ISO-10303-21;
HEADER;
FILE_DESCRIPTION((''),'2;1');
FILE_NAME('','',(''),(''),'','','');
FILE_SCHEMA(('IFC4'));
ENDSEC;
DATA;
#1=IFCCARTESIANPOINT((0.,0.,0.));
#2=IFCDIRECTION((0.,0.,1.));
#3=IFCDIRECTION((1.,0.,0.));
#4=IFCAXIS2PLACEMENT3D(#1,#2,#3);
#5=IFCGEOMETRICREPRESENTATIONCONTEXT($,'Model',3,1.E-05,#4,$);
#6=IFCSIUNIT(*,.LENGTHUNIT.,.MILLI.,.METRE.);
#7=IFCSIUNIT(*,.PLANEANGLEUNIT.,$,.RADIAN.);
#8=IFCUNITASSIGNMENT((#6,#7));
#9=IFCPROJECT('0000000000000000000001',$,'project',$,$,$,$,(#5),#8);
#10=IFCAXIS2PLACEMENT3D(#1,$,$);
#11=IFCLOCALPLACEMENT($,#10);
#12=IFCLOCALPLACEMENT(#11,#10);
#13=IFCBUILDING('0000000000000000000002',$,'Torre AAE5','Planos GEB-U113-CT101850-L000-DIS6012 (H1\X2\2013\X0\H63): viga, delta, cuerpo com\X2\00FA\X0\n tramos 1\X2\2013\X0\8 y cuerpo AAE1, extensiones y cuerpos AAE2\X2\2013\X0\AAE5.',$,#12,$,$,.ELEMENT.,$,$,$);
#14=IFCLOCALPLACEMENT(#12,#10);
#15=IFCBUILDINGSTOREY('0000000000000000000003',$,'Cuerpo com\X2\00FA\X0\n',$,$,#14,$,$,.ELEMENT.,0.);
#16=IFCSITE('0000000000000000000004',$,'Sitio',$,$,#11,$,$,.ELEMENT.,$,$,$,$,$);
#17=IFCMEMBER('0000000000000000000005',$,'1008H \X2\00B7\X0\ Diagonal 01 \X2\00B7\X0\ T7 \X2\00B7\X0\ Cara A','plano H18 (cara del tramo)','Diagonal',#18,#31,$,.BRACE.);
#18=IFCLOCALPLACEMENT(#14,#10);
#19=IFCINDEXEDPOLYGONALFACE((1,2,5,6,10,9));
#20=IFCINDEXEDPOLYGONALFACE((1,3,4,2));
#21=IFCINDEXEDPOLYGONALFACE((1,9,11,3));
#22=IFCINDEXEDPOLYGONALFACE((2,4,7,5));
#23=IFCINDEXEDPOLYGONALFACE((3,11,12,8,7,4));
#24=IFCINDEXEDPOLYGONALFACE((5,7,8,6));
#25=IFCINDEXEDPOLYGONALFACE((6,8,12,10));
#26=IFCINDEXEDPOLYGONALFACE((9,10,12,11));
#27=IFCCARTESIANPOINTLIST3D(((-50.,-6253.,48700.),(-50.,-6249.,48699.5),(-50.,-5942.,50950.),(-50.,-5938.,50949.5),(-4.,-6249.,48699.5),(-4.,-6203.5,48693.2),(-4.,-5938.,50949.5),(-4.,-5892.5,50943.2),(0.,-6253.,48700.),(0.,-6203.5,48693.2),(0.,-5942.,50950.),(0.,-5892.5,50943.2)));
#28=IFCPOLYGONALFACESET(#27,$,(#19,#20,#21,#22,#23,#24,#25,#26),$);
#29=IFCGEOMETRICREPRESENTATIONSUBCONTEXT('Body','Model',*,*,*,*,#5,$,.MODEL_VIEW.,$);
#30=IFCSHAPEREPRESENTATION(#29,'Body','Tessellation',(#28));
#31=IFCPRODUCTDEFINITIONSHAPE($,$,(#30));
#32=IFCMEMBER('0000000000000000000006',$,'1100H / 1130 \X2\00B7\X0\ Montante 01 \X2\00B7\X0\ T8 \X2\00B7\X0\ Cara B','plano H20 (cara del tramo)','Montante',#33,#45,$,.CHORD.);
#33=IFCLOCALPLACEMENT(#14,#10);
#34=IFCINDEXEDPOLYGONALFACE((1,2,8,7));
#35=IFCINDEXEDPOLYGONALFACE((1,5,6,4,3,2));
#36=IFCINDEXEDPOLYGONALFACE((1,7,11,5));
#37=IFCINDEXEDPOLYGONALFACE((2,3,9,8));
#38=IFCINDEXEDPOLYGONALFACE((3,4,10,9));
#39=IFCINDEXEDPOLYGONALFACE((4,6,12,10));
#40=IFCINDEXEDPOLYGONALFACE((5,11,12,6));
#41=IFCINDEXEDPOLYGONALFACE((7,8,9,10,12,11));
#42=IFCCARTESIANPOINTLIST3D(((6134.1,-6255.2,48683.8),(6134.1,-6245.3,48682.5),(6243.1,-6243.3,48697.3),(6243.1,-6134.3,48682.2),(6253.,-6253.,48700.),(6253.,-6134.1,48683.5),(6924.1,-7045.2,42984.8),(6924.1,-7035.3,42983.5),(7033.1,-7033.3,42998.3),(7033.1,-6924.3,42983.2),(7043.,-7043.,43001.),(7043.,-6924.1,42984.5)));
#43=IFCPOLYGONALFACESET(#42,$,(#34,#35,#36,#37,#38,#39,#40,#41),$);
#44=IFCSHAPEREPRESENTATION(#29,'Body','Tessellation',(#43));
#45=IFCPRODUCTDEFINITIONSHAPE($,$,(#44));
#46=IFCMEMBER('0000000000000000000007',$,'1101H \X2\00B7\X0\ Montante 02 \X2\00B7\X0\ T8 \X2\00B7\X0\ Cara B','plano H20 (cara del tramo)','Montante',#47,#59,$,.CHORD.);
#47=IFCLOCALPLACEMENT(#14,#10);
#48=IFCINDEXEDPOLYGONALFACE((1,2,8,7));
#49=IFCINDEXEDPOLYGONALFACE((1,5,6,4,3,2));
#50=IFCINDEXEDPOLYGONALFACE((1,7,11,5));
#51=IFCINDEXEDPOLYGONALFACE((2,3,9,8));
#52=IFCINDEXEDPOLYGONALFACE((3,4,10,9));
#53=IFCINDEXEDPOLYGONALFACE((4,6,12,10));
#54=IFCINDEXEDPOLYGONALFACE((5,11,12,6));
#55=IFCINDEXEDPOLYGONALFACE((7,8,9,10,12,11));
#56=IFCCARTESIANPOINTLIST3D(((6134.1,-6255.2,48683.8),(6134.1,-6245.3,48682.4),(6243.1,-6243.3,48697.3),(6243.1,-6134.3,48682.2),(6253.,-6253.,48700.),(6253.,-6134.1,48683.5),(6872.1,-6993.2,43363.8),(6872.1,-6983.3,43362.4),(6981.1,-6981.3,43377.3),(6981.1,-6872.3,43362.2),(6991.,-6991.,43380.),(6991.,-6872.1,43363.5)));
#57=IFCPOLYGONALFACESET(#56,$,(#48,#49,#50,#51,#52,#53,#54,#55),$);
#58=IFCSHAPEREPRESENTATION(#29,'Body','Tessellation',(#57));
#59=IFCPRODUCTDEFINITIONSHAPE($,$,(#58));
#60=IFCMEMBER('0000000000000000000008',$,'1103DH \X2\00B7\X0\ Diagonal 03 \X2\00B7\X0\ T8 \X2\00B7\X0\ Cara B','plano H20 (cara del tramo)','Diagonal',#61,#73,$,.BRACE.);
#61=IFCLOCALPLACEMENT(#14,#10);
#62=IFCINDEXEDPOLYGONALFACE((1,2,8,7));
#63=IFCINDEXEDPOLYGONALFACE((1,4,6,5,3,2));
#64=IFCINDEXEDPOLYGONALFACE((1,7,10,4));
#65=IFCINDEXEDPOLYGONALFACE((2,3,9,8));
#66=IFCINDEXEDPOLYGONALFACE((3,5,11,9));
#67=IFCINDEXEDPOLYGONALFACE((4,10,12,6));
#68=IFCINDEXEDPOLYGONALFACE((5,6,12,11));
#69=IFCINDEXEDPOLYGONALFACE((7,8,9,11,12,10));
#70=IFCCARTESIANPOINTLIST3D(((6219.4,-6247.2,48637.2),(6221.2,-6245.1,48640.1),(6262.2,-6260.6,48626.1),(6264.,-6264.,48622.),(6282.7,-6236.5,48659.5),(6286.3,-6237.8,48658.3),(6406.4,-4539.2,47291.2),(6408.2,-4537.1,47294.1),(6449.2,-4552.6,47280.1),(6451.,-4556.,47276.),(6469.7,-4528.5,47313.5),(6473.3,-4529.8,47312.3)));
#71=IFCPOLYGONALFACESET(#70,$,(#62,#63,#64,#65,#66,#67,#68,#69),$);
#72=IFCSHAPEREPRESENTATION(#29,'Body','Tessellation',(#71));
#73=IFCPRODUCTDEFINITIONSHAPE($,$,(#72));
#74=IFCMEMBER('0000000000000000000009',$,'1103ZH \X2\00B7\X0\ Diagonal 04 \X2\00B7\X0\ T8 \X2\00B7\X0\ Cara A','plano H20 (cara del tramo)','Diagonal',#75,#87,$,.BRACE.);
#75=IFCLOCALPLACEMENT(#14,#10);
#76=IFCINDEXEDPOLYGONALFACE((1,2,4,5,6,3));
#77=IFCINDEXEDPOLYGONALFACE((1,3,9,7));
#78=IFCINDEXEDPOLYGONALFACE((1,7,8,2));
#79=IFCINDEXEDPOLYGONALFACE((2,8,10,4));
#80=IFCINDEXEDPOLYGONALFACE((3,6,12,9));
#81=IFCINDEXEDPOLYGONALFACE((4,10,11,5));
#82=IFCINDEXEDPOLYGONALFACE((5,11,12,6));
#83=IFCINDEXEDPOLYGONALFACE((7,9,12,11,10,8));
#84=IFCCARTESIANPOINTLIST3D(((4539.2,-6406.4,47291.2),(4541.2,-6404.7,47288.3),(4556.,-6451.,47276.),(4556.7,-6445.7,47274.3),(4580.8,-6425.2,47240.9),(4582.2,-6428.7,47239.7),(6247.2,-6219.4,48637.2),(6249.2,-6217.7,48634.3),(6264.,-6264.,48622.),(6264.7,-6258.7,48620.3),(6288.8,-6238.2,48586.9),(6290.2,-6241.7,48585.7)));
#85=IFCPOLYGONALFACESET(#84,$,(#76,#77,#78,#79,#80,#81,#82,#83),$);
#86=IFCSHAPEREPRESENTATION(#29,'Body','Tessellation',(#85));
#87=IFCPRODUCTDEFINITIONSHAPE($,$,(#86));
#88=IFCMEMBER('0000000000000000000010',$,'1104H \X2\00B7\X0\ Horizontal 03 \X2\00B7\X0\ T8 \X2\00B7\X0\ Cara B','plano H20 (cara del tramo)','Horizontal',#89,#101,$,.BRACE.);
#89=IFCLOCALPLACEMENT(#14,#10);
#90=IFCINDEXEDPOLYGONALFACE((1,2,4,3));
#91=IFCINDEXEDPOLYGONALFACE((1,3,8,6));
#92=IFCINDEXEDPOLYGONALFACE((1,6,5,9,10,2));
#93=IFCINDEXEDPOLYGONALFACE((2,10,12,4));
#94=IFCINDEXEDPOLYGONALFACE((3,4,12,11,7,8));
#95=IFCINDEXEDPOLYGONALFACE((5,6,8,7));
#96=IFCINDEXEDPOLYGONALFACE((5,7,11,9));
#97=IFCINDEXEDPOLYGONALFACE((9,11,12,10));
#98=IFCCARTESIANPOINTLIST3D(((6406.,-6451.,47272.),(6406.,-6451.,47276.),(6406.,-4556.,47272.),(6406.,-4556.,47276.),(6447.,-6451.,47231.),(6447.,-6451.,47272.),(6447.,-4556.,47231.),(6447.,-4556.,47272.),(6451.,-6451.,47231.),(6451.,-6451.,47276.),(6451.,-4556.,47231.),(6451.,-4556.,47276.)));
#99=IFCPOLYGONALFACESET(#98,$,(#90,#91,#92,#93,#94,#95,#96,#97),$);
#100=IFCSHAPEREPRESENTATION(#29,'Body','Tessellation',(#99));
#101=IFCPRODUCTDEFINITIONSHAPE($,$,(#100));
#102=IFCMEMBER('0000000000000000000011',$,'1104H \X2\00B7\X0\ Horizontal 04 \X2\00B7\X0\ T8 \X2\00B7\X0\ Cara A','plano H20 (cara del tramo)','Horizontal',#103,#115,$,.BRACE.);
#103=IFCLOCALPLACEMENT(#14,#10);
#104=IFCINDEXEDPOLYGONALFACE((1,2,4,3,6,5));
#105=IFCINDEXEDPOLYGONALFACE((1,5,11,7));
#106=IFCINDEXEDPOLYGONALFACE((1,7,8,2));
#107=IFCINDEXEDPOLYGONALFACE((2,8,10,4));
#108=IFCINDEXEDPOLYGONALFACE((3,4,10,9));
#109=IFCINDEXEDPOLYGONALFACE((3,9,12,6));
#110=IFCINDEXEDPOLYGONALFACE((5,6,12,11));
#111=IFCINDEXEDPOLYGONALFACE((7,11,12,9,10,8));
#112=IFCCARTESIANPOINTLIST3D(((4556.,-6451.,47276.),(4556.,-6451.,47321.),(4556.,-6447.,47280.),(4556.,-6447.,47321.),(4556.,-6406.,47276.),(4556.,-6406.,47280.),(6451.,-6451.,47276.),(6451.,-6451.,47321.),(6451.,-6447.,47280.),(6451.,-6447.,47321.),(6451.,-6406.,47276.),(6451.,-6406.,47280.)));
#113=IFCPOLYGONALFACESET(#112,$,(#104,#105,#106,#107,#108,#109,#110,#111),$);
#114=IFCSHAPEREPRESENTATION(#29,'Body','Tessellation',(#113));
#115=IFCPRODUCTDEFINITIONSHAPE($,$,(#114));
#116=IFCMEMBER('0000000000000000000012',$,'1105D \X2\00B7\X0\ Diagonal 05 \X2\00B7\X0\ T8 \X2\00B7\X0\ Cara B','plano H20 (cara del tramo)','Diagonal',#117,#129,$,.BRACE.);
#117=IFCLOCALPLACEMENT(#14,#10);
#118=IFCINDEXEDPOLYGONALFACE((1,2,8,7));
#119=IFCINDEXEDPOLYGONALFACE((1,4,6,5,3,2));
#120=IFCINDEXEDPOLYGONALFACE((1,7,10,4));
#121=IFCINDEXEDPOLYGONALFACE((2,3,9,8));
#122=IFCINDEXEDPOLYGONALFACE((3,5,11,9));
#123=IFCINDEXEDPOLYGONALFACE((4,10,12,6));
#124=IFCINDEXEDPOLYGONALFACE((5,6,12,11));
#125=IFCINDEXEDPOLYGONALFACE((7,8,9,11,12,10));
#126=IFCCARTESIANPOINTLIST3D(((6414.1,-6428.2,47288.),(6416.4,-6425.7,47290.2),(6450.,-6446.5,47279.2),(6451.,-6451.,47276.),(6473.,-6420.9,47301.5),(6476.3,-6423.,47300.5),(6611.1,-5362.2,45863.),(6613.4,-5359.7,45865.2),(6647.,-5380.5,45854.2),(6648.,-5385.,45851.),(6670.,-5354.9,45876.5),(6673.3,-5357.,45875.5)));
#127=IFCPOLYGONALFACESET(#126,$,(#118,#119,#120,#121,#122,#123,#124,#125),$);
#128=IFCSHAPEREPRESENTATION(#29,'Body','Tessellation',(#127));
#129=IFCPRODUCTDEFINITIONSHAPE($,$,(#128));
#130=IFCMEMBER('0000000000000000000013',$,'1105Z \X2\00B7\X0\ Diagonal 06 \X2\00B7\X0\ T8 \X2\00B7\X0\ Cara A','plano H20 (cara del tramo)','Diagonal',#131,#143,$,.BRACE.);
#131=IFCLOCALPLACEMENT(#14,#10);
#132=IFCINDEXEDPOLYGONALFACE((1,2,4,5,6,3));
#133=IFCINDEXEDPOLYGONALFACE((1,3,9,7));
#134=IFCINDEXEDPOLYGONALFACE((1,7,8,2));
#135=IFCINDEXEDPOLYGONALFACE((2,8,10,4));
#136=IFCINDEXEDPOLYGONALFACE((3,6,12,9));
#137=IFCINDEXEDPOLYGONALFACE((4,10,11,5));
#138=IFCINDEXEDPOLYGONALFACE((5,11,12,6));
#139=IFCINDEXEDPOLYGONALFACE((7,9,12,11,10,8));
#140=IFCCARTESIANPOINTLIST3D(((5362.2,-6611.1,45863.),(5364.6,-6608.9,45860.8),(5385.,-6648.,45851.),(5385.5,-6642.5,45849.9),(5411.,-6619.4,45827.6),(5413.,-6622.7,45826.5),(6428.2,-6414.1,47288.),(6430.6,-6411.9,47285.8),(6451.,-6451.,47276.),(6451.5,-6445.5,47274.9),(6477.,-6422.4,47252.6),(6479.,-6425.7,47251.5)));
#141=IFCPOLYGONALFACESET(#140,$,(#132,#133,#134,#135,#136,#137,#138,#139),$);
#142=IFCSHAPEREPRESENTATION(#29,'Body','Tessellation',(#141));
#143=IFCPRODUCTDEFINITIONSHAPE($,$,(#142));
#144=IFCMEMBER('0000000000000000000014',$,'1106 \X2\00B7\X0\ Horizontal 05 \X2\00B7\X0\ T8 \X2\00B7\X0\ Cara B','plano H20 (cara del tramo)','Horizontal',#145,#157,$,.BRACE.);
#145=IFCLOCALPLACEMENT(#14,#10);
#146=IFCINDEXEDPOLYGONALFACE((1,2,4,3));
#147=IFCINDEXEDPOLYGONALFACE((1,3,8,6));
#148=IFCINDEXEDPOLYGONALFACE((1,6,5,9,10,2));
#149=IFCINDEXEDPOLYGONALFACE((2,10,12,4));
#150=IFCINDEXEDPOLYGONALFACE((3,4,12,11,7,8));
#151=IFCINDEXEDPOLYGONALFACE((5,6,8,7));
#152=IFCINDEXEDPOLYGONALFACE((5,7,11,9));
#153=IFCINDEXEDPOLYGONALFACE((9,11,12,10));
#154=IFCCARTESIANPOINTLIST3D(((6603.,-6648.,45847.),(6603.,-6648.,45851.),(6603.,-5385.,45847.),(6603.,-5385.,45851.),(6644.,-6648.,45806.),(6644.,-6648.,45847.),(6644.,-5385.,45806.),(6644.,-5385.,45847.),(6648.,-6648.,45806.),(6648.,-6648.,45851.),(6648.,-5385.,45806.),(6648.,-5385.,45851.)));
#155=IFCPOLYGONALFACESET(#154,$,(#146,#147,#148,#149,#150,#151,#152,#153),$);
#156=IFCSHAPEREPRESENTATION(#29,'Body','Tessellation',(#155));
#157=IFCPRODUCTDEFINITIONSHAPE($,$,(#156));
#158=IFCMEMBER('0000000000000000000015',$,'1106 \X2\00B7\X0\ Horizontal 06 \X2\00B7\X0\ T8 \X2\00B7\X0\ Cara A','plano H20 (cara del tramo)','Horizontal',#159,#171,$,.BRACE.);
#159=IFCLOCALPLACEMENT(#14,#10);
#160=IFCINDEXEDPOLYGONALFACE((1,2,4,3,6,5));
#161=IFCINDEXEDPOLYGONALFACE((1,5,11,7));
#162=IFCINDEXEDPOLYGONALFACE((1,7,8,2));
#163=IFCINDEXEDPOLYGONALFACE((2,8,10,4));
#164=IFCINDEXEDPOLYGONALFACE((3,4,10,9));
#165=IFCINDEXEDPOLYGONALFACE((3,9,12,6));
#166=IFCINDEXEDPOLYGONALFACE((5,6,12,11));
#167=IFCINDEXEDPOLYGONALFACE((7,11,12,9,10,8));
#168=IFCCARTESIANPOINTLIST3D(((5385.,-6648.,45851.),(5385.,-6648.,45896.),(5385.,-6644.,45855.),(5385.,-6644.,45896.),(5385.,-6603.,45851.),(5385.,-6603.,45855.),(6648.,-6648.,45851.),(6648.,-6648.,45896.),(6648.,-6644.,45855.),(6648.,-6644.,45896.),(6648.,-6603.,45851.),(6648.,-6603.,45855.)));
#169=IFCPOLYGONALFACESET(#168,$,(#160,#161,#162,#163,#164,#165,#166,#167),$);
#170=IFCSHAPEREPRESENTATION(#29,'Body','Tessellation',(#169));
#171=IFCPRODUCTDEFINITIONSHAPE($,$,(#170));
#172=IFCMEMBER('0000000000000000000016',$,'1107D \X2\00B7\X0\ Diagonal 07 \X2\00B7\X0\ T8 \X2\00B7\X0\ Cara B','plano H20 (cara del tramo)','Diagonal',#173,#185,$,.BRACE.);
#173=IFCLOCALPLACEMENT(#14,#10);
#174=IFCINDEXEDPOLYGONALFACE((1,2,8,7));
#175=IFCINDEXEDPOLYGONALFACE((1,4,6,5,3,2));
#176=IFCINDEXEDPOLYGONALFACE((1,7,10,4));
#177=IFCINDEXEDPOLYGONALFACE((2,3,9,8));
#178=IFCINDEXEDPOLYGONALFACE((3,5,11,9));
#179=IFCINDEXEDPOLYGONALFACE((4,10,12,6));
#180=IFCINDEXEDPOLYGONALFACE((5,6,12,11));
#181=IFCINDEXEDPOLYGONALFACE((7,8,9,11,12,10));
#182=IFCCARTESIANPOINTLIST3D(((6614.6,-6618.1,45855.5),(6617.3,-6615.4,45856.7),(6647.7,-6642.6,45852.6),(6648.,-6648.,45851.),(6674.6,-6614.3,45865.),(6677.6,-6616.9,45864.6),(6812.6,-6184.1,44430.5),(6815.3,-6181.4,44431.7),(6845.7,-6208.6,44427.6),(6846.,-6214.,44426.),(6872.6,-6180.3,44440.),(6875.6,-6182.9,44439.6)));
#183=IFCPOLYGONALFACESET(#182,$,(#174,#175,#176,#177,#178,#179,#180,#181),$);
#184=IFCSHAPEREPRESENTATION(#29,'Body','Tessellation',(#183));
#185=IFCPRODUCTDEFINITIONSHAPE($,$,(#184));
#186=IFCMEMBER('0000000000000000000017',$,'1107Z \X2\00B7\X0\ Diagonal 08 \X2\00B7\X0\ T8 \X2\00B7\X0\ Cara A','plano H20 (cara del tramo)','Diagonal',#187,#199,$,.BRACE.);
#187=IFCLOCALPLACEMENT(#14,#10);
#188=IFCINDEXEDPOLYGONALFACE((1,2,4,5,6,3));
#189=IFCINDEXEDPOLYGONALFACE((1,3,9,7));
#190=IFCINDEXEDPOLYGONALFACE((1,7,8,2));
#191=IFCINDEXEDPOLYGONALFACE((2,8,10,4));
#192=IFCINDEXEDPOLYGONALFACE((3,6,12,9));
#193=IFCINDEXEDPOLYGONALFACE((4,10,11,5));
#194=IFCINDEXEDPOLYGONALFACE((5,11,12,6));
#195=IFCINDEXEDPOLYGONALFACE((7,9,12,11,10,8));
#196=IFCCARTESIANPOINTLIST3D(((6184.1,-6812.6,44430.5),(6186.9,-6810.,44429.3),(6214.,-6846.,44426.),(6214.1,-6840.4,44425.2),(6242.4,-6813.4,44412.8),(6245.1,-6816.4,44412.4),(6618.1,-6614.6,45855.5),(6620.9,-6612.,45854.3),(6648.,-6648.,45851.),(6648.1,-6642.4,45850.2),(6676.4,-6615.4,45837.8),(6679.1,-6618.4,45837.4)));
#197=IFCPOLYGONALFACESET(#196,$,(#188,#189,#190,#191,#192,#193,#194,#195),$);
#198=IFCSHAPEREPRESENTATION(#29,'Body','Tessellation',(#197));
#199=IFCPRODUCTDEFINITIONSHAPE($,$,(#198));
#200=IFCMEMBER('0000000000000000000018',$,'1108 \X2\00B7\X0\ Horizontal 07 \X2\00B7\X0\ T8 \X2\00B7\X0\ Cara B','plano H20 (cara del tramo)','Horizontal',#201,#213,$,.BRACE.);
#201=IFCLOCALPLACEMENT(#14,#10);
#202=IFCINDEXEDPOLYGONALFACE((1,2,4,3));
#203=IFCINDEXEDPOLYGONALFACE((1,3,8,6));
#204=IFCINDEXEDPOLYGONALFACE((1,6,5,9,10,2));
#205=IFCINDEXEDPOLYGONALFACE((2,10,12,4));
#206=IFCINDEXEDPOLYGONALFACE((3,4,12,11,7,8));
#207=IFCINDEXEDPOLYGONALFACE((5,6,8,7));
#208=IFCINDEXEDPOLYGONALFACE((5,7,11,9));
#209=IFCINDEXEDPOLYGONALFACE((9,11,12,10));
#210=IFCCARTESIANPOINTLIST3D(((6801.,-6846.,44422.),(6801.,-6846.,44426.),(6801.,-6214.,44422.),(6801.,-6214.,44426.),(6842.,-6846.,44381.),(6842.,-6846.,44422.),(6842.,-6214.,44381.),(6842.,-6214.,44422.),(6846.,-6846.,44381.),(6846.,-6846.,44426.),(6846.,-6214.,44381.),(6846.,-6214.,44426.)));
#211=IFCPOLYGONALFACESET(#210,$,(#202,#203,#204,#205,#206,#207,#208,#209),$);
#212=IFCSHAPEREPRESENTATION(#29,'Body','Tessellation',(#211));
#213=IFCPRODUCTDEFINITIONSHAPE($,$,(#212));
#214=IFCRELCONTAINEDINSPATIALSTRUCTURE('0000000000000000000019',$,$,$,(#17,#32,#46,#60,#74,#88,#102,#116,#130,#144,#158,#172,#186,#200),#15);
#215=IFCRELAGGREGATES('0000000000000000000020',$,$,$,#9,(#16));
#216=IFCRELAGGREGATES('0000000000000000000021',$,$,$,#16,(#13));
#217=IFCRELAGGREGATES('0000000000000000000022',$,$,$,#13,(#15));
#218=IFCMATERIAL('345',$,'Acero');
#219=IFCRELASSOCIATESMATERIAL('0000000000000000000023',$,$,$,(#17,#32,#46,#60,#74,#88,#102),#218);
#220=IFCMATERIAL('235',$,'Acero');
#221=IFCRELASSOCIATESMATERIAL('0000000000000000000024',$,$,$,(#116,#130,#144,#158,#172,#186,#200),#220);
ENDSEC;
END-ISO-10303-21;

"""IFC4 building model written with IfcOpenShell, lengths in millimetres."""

from ifc_helpers import new_model, si_unit, frame, frame_2d, origin, origin_with_axes, place, context, subcontext, project, spatial, l_section, extrude, material, element, save


model = new_model("IFC4")

# Units and contexts
model_context = context("Model", 3, precision=1e-05, world=origin_with_axes())
body_context = subcontext(model_context, "Body", "Model", "MODEL_VIEW")
ifc_project = project(units=[si_unit("LENGTHUNIT", "METRE", prefix="MILLI"), si_unit("PLANEANGLEUNIT", "RADIAN")], contexts=[model_context])

# Site, building, storey
site_placement = place(None, origin())
site = spatial("IfcSite", under=ifc_project, at=site_placement, Name="Sitio", CompositionType="ELEMENT")
building_placement = place(site_placement, origin())
building = spatial("IfcBuilding", under=site, at=building_placement, Name="Torre AAE5", Description="Planos GEB-U113-CT101850-L000-DIS6012 (H1–H63): viga, delta, cuerpo común tramos 1–8 y cuerpo AAE1, extensiones y cuerpos AAE2–AAE5.", CompositionType="ELEMENT")
storey_placement = place(building_placement, origin())
storey = spatial("IfcBuildingStorey", under=building, at=storey_placement, Name="Cuerpo común", CompositionType="ELEMENT", Elevation=0.0)

# Members
ifc_material_1 = material(Name="345", Category="Acero")
member_1_placement = place(storey_placement, frame((0.0, -6253.0, 48700.0), z_axis=(0.0, 0.13692, 0.990582), x_axis=(0.0, 0.990582, -0.13692)))
element("IfcMember", 1, at=member_1_placement, inside=storey, material=ifc_material_1, Name="1008H · Diagonal 01 · T7 · Cara A", Description="plano H18 (cara del tramo)", ObjectType="Diagonal", PredefinedType="BRACE", context=body_context, shape_type="SweptSolid", body=[
    extrude(l_section(Depth=50.0, Width=50.0, Thickness=4.0, at=frame_2d((25.0, 25.0))), None, (0.0, 0.0, 1.0), 2271.4),
])
member_2_placement = place(storey_placement, frame((6253.0, -6253.0, 48700.0), z_axis=(0.136032, -0.136032, -0.981321), x_axis=(-0.990705, -0.018678, -0.134743)))
element("IfcMember", 2, at=member_2_placement, inside=storey, material=ifc_material_1, Name="1100H / 1130 · Montante 01 · T8 · Cara B", Description="plano H20 (cara del tramo)", ObjectType="Montante", PredefinedType="CHORD", context=body_context, shape_type="SweptSolid", body=[
    extrude(l_section(Depth=120.0, Width=120.0, Thickness=10.0, at=frame_2d((60.0, 60.0))), None, (0.0, 0.0, 1.0), 5807.5),
])
member_3_placement = place(storey_placement, frame((6253.0, -6253.0, 48700.0), z_axis=(0.136127, -0.136127, -0.981295), x_axis=(-0.990691, -0.018705, -0.134836)))
element("IfcMember", 3, at=member_3_placement, inside=storey, material=ifc_material_1, Name="1101H · Montante 02 · T8 · Cara B", Description="plano H20 (cara del tramo)", ObjectType="Montante", PredefinedType="CHORD", context=body_context, shape_type="SweptSolid", body=[
    extrude(l_section(Depth=120.0, Width=120.0, Thickness=10.0, at=frame_2d((60.0, 60.0))), None, (0.0, 0.0, 1.0), 5421.4),
])
for number, where, z_axis, x_axis, name in (
    (4, (6264.0, -6264.0, 48622.0), (0.085676, 0.782536, -0.616682), (-0.891166, 0.336961, 0.303776), "1103DH · Diagonal 03 · T8 · Cara B"),
    (5, (6264.0, -6264.0, 48622.0), (-0.782536, -0.085676, -0.616682), (-0.336961, 0.891166, 0.303776), "1103ZH · Diagonal 04 · T8 · Cara A"),
):
    element("IfcMember", number, at=place(storey_placement, frame(where, z_axis=z_axis, x_axis=x_axis)), inside=storey, material=ifc_material_1, Name=name, Description="plano H20 (cara del tramo)", ObjectType="Diagonal", PredefinedType="BRACE", context=body_context, shape_type="SweptSolid", body=[
        extrude(l_section(Depth=50.0, Width=50.0, Thickness=4.0, at=frame_2d((25.0, 25.0))), None, (0.0, 0.0, 1.0), 2182.6),
    ])
for number, where, z_axis, x_axis, name in (
    (6, (6451.0, -4556.0, 47276.0), (0.0, -1.0, 0.0), (-1.0, 0.0, 0.0), "1104H · Horizontal 03 · T8 · Cara B"),
    (7, (4556.0, -6451.0, 47276.0), (1.0, 0.0, 0.0), (0.0, 1.0, 0.0), "1104H · Horizontal 04 · T8 · Cara A"),
):
    element("IfcMember", number, at=place(storey_placement, frame(where, z_axis=z_axis, x_axis=x_axis)), inside=storey, material=ifc_material_1, Name=name, Description="plano H20 (cara del tramo)", ObjectType="Horizontal", PredefinedType="BRACE", context=body_context, shape_type="SweptSolid", body=[
        extrude(l_section(Depth=45.0, Width=45.0, Thickness=4.0, at=frame_2d((22.5, 22.5))), None, (0.0, 0.0, 1.0), 1895.0),
    ])
ifc_material_2 = material(Name="235", Category="Acero")
for number, where, z_axis, x_axis, name in (
    (8, (6451.0, -6451.0, 47276.0), (0.110027, 0.595374, -0.79588), (-0.819305, 0.507658, 0.266499), "1105D · Diagonal 05 · T8 · Cara B"),
    (9, (6451.0, -6451.0, 47276.0), (-0.595374, -0.110027, -0.79588), (-0.507658, 0.819305, 0.266499), "1105Z · Diagonal 06 · T8 · Cara A"),
):
    element("IfcMember", number, at=place(storey_placement, frame(where, z_axis=z_axis, x_axis=x_axis)), inside=storey, material=ifc_material_2, Name=name, Description="plano H20 (cara del tramo)", ObjectType="Diagonal", PredefinedType="BRACE", context=body_context, shape_type="SweptSolid", body=[
        extrude(l_section(Depth=45.0, Width=45.0, Thickness=4.0, at=frame_2d((22.5, 22.5))), None, (0.0, 0.0, 1.0), 1790.5),
    ])
for number, where, z_axis, x_axis, name in (
    (10, (6648.0, -5385.0, 45851.0), (0.0, -1.0, 0.0), (-1.0, 0.0, 0.0), "1106 · Horizontal 05 · T8 · Cara B"),
    (11, (5385.0, -6648.0, 45851.0), (1.0, 0.0, 0.0), (0.0, 1.0, 0.0), "1106 · Horizontal 06 · T8 · Cara A"),
):
    element("IfcMember", number, at=place(storey_placement, frame(where, z_axis=z_axis, x_axis=x_axis)), inside=storey, material=ifc_material_2, Name=name, Description="plano H20 (cara del tramo)", ObjectType="Horizontal", PredefinedType="BRACE", context=body_context, shape_type="SweptSolid", body=[
        extrude(l_section(Depth=45.0, Width=45.0, Thickness=4.0, at=frame_2d((22.5, 22.5))), None, (0.0, 0.0, 1.0), 1263.0),
    ])
for number, where, z_axis, x_axis, name in (
    (12, (6648.0, -6648.0, 45851.0), (0.131761, 0.288808, -0.948277), (-0.741556, 0.663539, 0.099051), "1107D · Diagonal 07 · T8 · Cara B"),
    (13, (6648.0, -6648.0, 45851.0), (-0.288808, -0.131761, -0.948277), (-0.663539, 0.741556, 0.099051), "1107Z · Diagonal 08 · T8 · Cara A"),
):
    element("IfcMember", number, at=place(storey_placement, frame(where, z_axis=z_axis, x_axis=x_axis)), inside=storey, material=ifc_material_2, Name=name, Description="plano H20 (cara del tramo)", ObjectType="Diagonal", PredefinedType="BRACE", context=body_context, shape_type="SweptSolid", body=[
        extrude(l_section(Depth=45.0, Width=45.0, Thickness=4.0, at=frame_2d((22.5, 22.5))), None, (0.0, 0.0, 1.0), 1502.7),
    ])
for number, where, z_axis, x_axis, name in (
    (14, (6846.0, -6214.0, 44426.0), (0.0, -1.0, 0.0), (-1.0, 0.0, 0.0), "1108 · Horizontal 07 · T8 · Cara B"),
):
    element("IfcMember", number, at=place(storey_placement, frame(where, z_axis=z_axis, x_axis=x_axis)), inside=storey, material=ifc_material_2, Name=name, Description="plano H20 (cara del tramo)", ObjectType="Horizontal", PredefinedType="BRACE", context=body_context, shape_type="SweptSolid", body=[
        extrude(l_section(Depth=45.0, Width=45.0, Thickness=4.0, at=frame_2d((22.5, 22.5))), None, (0.0, 0.0, 1.0), 632.0),
    ])

save(model, "model.ifc")
